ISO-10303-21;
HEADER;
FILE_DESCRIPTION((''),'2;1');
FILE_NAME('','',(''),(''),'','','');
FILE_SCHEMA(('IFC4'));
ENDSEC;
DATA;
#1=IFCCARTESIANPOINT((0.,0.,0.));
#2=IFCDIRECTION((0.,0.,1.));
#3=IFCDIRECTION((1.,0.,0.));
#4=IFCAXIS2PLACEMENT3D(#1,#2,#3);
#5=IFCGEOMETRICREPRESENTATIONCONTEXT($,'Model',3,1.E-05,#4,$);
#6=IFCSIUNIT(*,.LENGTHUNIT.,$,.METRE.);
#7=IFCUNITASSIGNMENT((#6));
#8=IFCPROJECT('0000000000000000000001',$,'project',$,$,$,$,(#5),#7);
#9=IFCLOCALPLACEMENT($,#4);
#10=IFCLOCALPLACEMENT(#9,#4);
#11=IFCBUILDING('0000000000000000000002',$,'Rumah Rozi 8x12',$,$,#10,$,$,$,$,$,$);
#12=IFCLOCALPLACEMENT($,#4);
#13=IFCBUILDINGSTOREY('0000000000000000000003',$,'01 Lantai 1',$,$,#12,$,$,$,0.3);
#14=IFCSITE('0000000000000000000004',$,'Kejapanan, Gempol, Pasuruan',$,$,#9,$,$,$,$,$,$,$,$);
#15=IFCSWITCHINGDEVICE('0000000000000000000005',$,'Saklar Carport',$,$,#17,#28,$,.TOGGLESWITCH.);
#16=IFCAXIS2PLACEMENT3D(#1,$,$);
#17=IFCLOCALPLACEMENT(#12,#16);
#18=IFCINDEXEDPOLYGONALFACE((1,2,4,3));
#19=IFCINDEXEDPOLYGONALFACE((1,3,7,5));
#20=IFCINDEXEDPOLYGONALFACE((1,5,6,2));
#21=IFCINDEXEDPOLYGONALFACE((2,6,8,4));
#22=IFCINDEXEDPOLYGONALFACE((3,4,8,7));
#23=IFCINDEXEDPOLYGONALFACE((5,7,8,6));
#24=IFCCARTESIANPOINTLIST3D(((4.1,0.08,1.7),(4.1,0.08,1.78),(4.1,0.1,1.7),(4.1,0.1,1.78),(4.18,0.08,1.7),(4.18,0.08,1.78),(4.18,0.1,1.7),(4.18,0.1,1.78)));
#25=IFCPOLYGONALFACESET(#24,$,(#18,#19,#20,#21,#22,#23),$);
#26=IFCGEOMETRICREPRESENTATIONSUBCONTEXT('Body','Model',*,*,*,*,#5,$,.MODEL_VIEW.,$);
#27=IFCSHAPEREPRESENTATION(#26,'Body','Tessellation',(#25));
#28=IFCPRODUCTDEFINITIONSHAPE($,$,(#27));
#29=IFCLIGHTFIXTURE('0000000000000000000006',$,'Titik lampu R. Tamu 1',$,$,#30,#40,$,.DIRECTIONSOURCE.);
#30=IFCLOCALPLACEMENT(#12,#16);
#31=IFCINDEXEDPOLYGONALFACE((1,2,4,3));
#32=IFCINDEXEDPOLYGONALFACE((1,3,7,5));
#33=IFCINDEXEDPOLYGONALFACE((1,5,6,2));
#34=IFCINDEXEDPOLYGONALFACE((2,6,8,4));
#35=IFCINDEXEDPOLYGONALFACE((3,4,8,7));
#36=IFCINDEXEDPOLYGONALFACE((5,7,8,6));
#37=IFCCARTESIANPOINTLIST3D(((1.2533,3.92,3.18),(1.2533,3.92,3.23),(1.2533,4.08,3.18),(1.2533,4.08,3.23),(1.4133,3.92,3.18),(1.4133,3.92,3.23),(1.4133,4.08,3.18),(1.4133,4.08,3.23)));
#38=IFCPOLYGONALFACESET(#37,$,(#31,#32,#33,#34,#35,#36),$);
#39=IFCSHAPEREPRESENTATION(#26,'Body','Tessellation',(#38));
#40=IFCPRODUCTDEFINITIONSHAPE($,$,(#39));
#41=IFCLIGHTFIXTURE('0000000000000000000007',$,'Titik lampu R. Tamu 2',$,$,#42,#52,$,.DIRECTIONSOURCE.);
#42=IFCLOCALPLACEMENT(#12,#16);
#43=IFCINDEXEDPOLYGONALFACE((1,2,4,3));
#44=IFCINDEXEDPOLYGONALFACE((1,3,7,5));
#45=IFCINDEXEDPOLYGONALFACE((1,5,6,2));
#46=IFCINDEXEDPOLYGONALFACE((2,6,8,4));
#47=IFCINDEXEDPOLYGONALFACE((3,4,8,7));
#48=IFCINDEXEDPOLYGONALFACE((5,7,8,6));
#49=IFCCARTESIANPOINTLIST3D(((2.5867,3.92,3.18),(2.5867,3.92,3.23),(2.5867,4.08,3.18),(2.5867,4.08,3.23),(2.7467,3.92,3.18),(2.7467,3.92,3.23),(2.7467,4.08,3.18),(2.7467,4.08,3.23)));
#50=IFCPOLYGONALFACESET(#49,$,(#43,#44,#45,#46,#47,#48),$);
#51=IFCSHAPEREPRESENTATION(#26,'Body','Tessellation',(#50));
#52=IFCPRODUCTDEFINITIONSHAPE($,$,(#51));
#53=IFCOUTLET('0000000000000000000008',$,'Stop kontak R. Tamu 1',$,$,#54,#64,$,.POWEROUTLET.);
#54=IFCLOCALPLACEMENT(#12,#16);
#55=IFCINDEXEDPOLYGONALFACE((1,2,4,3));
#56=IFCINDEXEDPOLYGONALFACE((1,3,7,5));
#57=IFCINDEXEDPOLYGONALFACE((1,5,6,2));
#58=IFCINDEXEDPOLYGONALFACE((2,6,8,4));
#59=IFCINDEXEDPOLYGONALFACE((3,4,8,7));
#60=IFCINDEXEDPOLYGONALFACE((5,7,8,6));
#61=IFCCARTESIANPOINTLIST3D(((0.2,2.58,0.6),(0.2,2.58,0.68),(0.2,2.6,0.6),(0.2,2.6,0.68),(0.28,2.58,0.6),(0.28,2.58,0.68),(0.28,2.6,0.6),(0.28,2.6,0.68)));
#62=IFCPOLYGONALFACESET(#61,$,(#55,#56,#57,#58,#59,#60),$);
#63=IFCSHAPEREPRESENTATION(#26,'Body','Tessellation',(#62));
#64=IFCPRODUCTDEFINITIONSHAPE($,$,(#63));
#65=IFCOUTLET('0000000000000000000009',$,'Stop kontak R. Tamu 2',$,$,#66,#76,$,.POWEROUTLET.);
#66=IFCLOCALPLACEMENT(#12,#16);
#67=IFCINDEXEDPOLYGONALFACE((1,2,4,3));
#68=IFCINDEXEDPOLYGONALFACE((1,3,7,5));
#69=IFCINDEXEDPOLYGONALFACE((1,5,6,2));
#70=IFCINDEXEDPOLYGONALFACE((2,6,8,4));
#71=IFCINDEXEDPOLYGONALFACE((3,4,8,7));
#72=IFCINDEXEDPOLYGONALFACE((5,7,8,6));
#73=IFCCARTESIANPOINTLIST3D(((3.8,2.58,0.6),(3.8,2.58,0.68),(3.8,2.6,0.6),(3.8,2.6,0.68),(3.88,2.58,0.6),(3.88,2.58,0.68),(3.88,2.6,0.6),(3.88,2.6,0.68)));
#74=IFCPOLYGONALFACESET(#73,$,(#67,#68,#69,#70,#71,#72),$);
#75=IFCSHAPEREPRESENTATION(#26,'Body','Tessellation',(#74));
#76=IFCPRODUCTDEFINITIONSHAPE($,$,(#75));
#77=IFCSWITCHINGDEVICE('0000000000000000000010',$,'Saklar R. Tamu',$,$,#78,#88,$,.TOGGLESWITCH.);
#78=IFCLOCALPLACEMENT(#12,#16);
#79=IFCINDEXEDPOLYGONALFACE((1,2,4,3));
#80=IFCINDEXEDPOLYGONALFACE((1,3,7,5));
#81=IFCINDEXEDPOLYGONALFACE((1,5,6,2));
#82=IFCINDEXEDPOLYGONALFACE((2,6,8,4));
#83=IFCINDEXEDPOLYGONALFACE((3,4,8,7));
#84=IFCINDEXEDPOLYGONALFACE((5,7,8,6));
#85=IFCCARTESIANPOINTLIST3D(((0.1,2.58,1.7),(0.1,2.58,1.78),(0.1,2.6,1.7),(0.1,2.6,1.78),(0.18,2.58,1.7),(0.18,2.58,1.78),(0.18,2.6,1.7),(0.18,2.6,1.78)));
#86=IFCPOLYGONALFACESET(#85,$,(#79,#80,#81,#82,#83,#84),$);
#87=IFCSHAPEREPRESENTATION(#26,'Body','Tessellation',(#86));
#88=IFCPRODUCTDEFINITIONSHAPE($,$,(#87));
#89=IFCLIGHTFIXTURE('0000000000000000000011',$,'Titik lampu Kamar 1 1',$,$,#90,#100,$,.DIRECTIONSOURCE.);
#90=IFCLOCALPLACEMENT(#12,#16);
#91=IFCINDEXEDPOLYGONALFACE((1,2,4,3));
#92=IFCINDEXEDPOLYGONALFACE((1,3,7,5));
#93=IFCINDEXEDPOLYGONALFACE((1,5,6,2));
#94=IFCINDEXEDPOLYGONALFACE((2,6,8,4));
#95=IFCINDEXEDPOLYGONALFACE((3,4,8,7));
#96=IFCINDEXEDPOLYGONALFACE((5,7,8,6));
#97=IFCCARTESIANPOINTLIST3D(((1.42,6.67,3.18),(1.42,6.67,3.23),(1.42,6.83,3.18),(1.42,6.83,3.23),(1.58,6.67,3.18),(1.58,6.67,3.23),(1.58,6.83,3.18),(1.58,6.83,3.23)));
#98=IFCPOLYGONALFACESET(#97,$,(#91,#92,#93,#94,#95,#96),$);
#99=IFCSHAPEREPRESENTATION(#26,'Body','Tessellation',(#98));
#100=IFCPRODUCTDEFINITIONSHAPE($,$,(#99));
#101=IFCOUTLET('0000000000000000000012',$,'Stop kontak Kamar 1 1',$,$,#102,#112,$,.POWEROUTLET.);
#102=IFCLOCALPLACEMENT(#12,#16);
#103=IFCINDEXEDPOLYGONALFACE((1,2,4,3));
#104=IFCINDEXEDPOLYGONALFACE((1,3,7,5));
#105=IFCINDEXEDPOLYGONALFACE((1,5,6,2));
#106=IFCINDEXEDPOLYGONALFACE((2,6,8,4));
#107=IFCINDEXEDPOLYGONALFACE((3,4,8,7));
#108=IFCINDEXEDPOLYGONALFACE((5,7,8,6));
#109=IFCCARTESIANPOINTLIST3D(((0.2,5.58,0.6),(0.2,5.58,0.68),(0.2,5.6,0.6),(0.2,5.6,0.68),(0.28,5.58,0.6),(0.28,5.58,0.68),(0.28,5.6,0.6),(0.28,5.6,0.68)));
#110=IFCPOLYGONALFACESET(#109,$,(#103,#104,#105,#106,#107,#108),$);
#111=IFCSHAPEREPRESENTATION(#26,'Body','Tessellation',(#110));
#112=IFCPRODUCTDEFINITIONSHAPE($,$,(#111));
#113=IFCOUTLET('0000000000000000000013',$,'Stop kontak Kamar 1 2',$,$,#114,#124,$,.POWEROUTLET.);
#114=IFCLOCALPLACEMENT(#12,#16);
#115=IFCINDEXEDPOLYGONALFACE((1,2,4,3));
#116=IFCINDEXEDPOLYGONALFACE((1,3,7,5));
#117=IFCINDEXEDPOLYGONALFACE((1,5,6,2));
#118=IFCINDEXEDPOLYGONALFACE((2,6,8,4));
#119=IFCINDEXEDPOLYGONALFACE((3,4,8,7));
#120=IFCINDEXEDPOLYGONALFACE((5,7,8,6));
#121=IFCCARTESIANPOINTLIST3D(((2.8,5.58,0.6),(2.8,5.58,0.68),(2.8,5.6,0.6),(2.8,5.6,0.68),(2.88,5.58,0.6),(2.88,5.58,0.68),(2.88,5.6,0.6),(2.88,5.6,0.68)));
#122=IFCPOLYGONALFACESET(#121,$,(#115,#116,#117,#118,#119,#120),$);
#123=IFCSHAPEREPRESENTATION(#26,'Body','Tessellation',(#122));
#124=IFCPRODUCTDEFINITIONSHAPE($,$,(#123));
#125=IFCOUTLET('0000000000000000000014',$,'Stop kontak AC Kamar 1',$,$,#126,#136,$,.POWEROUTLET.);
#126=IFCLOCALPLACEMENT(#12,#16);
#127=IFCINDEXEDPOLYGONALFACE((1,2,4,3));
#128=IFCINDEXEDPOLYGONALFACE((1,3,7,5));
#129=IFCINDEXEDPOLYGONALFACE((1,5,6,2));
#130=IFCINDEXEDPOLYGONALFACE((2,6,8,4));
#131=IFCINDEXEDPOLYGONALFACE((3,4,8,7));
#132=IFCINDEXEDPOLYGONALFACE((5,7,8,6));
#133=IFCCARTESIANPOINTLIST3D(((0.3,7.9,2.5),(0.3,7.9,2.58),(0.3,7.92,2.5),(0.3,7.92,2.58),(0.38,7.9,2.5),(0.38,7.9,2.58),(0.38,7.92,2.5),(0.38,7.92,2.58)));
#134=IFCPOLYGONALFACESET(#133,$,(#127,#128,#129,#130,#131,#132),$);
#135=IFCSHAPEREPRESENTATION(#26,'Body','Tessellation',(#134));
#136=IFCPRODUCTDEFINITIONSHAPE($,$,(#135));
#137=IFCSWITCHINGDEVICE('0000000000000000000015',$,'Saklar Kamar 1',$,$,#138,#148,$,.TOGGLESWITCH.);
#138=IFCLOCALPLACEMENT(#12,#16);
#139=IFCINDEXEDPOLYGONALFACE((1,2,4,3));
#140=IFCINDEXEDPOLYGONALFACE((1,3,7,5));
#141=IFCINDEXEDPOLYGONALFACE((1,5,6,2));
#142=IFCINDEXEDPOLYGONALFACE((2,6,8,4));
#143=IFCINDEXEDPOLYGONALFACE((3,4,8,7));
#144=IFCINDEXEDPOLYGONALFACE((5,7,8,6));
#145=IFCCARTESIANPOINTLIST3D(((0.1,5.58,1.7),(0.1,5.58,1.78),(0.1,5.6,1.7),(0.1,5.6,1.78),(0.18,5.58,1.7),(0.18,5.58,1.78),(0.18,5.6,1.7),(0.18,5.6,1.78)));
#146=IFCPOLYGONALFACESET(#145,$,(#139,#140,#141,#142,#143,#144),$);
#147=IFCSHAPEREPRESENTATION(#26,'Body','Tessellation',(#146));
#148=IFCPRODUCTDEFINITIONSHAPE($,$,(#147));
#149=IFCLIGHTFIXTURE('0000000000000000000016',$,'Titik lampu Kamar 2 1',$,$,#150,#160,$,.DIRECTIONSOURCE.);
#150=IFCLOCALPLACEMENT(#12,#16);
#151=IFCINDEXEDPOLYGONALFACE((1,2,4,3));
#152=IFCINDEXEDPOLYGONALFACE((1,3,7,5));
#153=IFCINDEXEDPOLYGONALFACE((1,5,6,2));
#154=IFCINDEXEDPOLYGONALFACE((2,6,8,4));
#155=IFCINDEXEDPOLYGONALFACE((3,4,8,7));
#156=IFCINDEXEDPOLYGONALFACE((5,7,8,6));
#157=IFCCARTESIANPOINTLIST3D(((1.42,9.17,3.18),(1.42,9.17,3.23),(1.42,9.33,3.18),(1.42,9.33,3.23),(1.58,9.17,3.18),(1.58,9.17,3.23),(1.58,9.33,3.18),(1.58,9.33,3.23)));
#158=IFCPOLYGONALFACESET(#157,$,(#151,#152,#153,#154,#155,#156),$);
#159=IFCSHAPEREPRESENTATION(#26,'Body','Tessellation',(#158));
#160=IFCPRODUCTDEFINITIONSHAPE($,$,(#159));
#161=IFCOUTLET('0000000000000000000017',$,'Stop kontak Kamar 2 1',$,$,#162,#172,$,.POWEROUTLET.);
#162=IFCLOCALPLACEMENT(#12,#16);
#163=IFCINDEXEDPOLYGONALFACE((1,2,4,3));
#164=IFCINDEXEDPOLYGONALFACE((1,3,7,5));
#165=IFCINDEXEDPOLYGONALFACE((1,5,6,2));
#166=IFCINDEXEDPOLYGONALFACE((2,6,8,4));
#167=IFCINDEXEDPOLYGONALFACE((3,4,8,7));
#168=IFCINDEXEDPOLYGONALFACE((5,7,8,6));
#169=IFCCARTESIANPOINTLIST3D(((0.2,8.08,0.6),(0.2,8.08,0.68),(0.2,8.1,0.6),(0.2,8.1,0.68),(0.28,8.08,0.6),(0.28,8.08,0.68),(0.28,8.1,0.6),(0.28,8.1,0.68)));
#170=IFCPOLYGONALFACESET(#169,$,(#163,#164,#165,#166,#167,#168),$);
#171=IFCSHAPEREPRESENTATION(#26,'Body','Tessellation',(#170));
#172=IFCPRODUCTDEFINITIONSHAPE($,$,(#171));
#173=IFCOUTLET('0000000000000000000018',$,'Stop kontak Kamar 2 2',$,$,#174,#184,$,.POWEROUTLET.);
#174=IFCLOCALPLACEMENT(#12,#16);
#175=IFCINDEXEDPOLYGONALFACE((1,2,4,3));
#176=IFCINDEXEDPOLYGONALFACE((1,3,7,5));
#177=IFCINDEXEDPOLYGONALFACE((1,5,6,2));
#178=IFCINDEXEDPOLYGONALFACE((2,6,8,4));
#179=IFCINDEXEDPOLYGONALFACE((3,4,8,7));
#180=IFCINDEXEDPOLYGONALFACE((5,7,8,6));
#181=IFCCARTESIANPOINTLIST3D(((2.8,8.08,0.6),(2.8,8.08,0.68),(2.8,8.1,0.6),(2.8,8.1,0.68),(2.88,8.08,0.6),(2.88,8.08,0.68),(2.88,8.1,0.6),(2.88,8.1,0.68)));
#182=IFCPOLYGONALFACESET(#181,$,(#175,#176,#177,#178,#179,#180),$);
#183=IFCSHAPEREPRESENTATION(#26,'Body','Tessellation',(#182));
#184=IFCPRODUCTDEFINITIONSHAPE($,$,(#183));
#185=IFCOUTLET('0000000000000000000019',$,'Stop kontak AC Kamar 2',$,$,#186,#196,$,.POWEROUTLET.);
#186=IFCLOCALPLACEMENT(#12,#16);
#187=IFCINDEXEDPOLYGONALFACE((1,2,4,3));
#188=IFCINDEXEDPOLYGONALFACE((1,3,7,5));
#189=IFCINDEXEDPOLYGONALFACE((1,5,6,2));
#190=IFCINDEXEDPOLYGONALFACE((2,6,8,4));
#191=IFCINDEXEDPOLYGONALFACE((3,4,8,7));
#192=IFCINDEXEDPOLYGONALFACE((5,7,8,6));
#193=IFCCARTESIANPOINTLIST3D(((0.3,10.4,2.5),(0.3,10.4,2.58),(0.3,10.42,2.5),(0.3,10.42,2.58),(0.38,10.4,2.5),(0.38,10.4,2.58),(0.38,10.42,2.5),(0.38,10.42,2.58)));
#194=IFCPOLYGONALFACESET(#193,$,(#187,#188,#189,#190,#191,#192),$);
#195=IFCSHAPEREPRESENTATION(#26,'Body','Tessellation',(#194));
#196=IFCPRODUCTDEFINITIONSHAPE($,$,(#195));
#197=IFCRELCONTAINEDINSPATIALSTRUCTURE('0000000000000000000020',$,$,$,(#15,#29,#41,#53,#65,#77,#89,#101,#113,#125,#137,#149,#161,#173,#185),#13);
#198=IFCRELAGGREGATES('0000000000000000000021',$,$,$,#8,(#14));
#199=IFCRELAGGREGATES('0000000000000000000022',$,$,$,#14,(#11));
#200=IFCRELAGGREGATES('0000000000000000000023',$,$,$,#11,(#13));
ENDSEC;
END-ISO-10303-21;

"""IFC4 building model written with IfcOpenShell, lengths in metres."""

from ifc_helpers import new_model, si_unit, frame, origin_with_axes, place, context, subcontext, project, spatial, line, indexed_curve, outline, extrude, element, save


model = new_model("IFC4")

# Units and contexts
model_context = context("Model", 3, precision=1e-05, world=origin_with_axes())
body_context = subcontext(model_context, "Body", "Model", "MODEL_VIEW")
ifc_project = project(units=[si_unit("LENGTHUNIT", "METRE")], contexts=[model_context])

# Site, building, storey
site_placement = place(None, origin_with_axes())
site = spatial("IfcSite", under=ifc_project, at=site_placement, Name="Kejapanan, Gempol, Pasuruan")
building_placement = place(site_placement, origin_with_axes())
building = spatial("IfcBuilding", under=site, at=building_placement, Name="Rumah Rozi 8x12")
storey_placement = place(None, origin_with_axes())
storey = spatial("IfcBuildingStorey", under=building, at=storey_placement, Name="01 Lantai 1", Elevation=0.3)

# Switching device
switching_device_1_placement = place(storey_placement, origin_with_axes())
element("IfcSwitchingDevice", 1, at=switching_device_1_placement, inside=storey, Name="Saklar Carport", PredefinedType="TOGGLESWITCH", context=body_context, shape_type="SweptSolid", body=[
    extrude(outline(indexed_curve([(4.1, 0.08), (4.18, 0.08), (4.18, 0.1), (4.1, 0.1)], segments=[line(1, 2, 3, 4, 1)])), frame((0.0, 0.0, 1.7), z_axis=(0.0, 0.0, 1.0), x_axis=(1.0, 0.0, 0.0)), (0.0, 0.0, 1.0), 0.08),
])

# Light fixtures
light_fixture_1_placement = place(storey_placement, origin_with_axes())
element("IfcLightFixture", 2, at=light_fixture_1_placement, inside=storey, Name="Titik lampu R. Tamu 1", PredefinedType="DIRECTIONSOURCE", context=body_context, shape_type="SweptSolid", body=[
    extrude(outline(indexed_curve([(1.2533, 3.92), (1.4133, 3.92), (1.4133, 4.08), (1.2533, 4.08)], segments=[line(1, 2, 3, 4, 1)])), frame((0.0, 0.0, 3.18), z_axis=(0.0, 0.0, 1.0), x_axis=(1.0, 0.0, 0.0)), (0.0, 0.0, 1.0), 0.05),
])
light_fixture_2_placement = place(storey_placement, origin_with_axes())
element("IfcLightFixture", 3, at=light_fixture_2_placement, inside=storey, Name="Titik lampu R. Tamu 2", PredefinedType="DIRECTIONSOURCE", context=body_context, shape_type="SweptSolid", body=[
    extrude(outline(indexed_curve([(2.5867, 3.92), (2.7467, 3.92), (2.7467, 4.08), (2.5867, 4.08)], segments=[line(1, 2, 3, 4, 1)])), frame((0.0, 0.0, 3.18), z_axis=(0.0, 0.0, 1.0), x_axis=(1.0, 0.0, 0.0)), (0.0, 0.0, 1.0), 0.05),
])

# Outlets
outlet_1_placement = place(storey_placement, origin_with_axes())
element("IfcOutlet", 4, at=outlet_1_placement, inside=storey, Name="Stop kontak R. Tamu 1", PredefinedType="POWEROUTLET", context=body_context, shape_type="SweptSolid", body=[
    extrude(outline(indexed_curve([(0.2, 2.58), (0.28, 2.58), (0.28, 2.6), (0.2, 2.6)], segments=[line(1, 2, 3, 4, 1)])), frame((0.0, 0.0, 0.6), z_axis=(0.0, 0.0, 1.0), x_axis=(1.0, 0.0, 0.0)), (0.0, 0.0, 1.0), 0.08),
])
outlet_2_placement = place(storey_placement, origin_with_axes())
element("IfcOutlet", 5, at=outlet_2_placement, inside=storey, Name="Stop kontak R. Tamu 2", PredefinedType="POWEROUTLET", context=body_context, shape_type="SweptSolid", body=[
    extrude(outline(indexed_curve([(3.8, 2.58), (3.88, 2.58), (3.88, 2.6), (3.8, 2.6)], segments=[line(1, 2, 3, 4, 1)])), frame((0.0, 0.0, 0.6), z_axis=(0.0, 0.0, 1.0), x_axis=(1.0, 0.0, 0.0)), (0.0, 0.0, 1.0), 0.08),
])

# Switching device
switching_device_2_placement = place(storey_placement, origin_with_axes())
element("IfcSwitchingDevice", 6, at=switching_device_2_placement, inside=storey, Name="Saklar R. Tamu", PredefinedType="TOGGLESWITCH", context=body_context, shape_type="SweptSolid", body=[
    extrude(outline(indexed_curve([(0.1, 2.58), (0.18, 2.58), (0.18, 2.6), (0.1, 2.6)], segments=[line(1, 2, 3, 4, 1)])), frame((0.0, 0.0, 1.7), z_axis=(0.0, 0.0, 1.0), x_axis=(1.0, 0.0, 0.0)), (0.0, 0.0, 1.0), 0.08),
])

# Light fixture
light_fixture_3_placement = place(storey_placement, origin_with_axes())
element("IfcLightFixture", 7, at=light_fixture_3_placement, inside=storey, Name="Titik lampu Kamar 1 1", PredefinedType="DIRECTIONSOURCE", context=body_context, shape_type="SweptSolid", body=[
    extrude(outline(indexed_curve([(1.42, 6.67), (1.58, 6.67), (1.58, 6.83), (1.42, 6.83)], segments=[line(1, 2, 3, 4, 1)])), frame((0.0, 0.0, 3.18), z_axis=(0.0, 0.0, 1.0), x_axis=(1.0, 0.0, 0.0)), (0.0, 0.0, 1.0), 0.05),
])

# Outlets
outlet_3_placement = place(storey_placement, origin_with_axes())
element("IfcOutlet", 8, at=outlet_3_placement, inside=storey, Name="Stop kontak Kamar 1 1", PredefinedType="POWEROUTLET", context=body_context, shape_type="SweptSolid", body=[
    extrude(outline(indexed_curve([(0.2, 5.58), (0.28, 5.58), (0.28, 5.6), (0.2, 5.6)], segments=[line(1, 2, 3, 4, 1)])), frame((0.0, 0.0, 0.6), z_axis=(0.0, 0.0, 1.0), x_axis=(1.0, 0.0, 0.0)), (0.0, 0.0, 1.0), 0.08),
])
outlet_4_placement = place(storey_placement, origin_with_axes())
element("IfcOutlet", 9, at=outlet_4_placement, inside=storey, Name="Stop kontak Kamar 1 2", PredefinedType="POWEROUTLET", context=body_context, shape_type="SweptSolid", body=[
    extrude(outline(indexed_curve([(2.8, 5.58), (2.88, 5.58), (2.88, 5.6), (2.8, 5.6)], segments=[line(1, 2, 3, 4, 1)])), frame((0.0, 0.0, 0.6), z_axis=(0.0, 0.0, 1.0), x_axis=(1.0, 0.0, 0.0)), (0.0, 0.0, 1.0), 0.08),
])
outlet_5_placement = place(storey_placement, origin_with_axes())
element("IfcOutlet", 10, at=outlet_5_placement, inside=storey, Name="Stop kontak AC Kamar 1", PredefinedType="POWEROUTLET", context=body_context, shape_type="SweptSolid", body=[
    extrude(outline(indexed_curve([(0.3, 7.9), (0.38, 7.9), (0.38, 7.92), (0.3, 7.92)], segments=[line(1, 2, 3, 4, 1)])), frame((0.0, 0.0, 2.5), z_axis=(0.0, 0.0, 1.0), x_axis=(1.0, 0.0, 0.0)), (0.0, 0.0, 1.0), 0.08),
])

# Switching device
switching_device_3_placement = place(storey_placement, origin_with_axes())
element("IfcSwitchingDevice", 11, at=switching_device_3_placement, inside=storey, Name="Saklar Kamar 1", PredefinedType="TOGGLESWITCH", context=body_context, shape_type="SweptSolid", body=[
    extrude(outline(indexed_curve([(0.1, 5.58), (0.18, 5.58), (0.18, 5.6), (0.1, 5.6)], segments=[line(1, 2, 3, 4, 1)])), frame((0.0, 0.0, 1.7), z_axis=(0.0, 0.0, 1.0), x_axis=(1.0, 0.0, 0.0)), (0.0, 0.0, 1.0), 0.08),
])

# Light fixture
light_fixture_4_placement = place(storey_placement, origin_with_axes())
element("IfcLightFixture", 12, at=light_fixture_4_placement, inside=storey, Name="Titik lampu Kamar 2 1", PredefinedType="DIRECTIONSOURCE", context=body_context, shape_type="SweptSolid", body=[
    extrude(outline(indexed_curve([(1.42, 9.17), (1.58, 9.17), (1.58, 9.33), (1.42, 9.33)], segments=[line(1, 2, 3, 4, 1)])), frame((0.0, 0.0, 3.18), z_axis=(0.0, 0.0, 1.0), x_axis=(1.0, 0.0, 0.0)), (0.0, 0.0, 1.0), 0.05),
])

# Outlets
outlet_6_placement = place(storey_placement, origin_with_axes())
element("IfcOutlet", 13, at=outlet_6_placement, inside=storey, Name="Stop kontak Kamar 2 1", PredefinedType="POWEROUTLET", context=body_context, shape_type="SweptSolid", body=[
    extrude(outline(indexed_curve([(0.2, 8.08), (0.28, 8.08), (0.28, 8.1), (0.2, 8.1)], segments=[line(1, 2, 3, 4, 1)])), frame((0.0, 0.0, 0.6), z_axis=(0.0, 0.0, 1.0), x_axis=(1.0, 0.0, 0.0)), (0.0, 0.0, 1.0), 0.08),
])
outlet_7_placement = place(storey_placement, origin_with_axes())
element("IfcOutlet", 14, at=outlet_7_placement, inside=storey, Name="Stop kontak Kamar 2 2", PredefinedType="POWEROUTLET", context=body_context, shape_type="SweptSolid", body=[
    extrude(outline(indexed_curve([(2.8, 8.08), (2.88, 8.08), (2.88, 8.1), (2.8, 8.1)], segments=[line(1, 2, 3, 4, 1)])), frame((0.0, 0.0, 0.6), z_axis=(0.0, 0.0, 1.0), x_axis=(1.0, 0.0, 0.0)), (0.0, 0.0, 1.0), 0.08),
])
outlet_8_placement = place(storey_placement, origin_with_axes())
element("IfcOutlet", 15, at=outlet_8_placement, inside=storey, Name="Stop kontak AC Kamar 2", PredefinedType="POWEROUTLET", context=body_context, shape_type="SweptSolid", body=[
    extrude(outline(indexed_curve([(0.3, 10.4), (0.38, 10.4), (0.38, 10.42), (0.3, 10.42)], segments=[line(1, 2, 3, 4, 1)])), frame((0.0, 0.0, 2.5), z_axis=(0.0, 0.0, 1.0), x_axis=(1.0, 0.0, 0.0)), (0.0, 0.0, 1.0), 0.08),
])

save(model, "model.ifc")
